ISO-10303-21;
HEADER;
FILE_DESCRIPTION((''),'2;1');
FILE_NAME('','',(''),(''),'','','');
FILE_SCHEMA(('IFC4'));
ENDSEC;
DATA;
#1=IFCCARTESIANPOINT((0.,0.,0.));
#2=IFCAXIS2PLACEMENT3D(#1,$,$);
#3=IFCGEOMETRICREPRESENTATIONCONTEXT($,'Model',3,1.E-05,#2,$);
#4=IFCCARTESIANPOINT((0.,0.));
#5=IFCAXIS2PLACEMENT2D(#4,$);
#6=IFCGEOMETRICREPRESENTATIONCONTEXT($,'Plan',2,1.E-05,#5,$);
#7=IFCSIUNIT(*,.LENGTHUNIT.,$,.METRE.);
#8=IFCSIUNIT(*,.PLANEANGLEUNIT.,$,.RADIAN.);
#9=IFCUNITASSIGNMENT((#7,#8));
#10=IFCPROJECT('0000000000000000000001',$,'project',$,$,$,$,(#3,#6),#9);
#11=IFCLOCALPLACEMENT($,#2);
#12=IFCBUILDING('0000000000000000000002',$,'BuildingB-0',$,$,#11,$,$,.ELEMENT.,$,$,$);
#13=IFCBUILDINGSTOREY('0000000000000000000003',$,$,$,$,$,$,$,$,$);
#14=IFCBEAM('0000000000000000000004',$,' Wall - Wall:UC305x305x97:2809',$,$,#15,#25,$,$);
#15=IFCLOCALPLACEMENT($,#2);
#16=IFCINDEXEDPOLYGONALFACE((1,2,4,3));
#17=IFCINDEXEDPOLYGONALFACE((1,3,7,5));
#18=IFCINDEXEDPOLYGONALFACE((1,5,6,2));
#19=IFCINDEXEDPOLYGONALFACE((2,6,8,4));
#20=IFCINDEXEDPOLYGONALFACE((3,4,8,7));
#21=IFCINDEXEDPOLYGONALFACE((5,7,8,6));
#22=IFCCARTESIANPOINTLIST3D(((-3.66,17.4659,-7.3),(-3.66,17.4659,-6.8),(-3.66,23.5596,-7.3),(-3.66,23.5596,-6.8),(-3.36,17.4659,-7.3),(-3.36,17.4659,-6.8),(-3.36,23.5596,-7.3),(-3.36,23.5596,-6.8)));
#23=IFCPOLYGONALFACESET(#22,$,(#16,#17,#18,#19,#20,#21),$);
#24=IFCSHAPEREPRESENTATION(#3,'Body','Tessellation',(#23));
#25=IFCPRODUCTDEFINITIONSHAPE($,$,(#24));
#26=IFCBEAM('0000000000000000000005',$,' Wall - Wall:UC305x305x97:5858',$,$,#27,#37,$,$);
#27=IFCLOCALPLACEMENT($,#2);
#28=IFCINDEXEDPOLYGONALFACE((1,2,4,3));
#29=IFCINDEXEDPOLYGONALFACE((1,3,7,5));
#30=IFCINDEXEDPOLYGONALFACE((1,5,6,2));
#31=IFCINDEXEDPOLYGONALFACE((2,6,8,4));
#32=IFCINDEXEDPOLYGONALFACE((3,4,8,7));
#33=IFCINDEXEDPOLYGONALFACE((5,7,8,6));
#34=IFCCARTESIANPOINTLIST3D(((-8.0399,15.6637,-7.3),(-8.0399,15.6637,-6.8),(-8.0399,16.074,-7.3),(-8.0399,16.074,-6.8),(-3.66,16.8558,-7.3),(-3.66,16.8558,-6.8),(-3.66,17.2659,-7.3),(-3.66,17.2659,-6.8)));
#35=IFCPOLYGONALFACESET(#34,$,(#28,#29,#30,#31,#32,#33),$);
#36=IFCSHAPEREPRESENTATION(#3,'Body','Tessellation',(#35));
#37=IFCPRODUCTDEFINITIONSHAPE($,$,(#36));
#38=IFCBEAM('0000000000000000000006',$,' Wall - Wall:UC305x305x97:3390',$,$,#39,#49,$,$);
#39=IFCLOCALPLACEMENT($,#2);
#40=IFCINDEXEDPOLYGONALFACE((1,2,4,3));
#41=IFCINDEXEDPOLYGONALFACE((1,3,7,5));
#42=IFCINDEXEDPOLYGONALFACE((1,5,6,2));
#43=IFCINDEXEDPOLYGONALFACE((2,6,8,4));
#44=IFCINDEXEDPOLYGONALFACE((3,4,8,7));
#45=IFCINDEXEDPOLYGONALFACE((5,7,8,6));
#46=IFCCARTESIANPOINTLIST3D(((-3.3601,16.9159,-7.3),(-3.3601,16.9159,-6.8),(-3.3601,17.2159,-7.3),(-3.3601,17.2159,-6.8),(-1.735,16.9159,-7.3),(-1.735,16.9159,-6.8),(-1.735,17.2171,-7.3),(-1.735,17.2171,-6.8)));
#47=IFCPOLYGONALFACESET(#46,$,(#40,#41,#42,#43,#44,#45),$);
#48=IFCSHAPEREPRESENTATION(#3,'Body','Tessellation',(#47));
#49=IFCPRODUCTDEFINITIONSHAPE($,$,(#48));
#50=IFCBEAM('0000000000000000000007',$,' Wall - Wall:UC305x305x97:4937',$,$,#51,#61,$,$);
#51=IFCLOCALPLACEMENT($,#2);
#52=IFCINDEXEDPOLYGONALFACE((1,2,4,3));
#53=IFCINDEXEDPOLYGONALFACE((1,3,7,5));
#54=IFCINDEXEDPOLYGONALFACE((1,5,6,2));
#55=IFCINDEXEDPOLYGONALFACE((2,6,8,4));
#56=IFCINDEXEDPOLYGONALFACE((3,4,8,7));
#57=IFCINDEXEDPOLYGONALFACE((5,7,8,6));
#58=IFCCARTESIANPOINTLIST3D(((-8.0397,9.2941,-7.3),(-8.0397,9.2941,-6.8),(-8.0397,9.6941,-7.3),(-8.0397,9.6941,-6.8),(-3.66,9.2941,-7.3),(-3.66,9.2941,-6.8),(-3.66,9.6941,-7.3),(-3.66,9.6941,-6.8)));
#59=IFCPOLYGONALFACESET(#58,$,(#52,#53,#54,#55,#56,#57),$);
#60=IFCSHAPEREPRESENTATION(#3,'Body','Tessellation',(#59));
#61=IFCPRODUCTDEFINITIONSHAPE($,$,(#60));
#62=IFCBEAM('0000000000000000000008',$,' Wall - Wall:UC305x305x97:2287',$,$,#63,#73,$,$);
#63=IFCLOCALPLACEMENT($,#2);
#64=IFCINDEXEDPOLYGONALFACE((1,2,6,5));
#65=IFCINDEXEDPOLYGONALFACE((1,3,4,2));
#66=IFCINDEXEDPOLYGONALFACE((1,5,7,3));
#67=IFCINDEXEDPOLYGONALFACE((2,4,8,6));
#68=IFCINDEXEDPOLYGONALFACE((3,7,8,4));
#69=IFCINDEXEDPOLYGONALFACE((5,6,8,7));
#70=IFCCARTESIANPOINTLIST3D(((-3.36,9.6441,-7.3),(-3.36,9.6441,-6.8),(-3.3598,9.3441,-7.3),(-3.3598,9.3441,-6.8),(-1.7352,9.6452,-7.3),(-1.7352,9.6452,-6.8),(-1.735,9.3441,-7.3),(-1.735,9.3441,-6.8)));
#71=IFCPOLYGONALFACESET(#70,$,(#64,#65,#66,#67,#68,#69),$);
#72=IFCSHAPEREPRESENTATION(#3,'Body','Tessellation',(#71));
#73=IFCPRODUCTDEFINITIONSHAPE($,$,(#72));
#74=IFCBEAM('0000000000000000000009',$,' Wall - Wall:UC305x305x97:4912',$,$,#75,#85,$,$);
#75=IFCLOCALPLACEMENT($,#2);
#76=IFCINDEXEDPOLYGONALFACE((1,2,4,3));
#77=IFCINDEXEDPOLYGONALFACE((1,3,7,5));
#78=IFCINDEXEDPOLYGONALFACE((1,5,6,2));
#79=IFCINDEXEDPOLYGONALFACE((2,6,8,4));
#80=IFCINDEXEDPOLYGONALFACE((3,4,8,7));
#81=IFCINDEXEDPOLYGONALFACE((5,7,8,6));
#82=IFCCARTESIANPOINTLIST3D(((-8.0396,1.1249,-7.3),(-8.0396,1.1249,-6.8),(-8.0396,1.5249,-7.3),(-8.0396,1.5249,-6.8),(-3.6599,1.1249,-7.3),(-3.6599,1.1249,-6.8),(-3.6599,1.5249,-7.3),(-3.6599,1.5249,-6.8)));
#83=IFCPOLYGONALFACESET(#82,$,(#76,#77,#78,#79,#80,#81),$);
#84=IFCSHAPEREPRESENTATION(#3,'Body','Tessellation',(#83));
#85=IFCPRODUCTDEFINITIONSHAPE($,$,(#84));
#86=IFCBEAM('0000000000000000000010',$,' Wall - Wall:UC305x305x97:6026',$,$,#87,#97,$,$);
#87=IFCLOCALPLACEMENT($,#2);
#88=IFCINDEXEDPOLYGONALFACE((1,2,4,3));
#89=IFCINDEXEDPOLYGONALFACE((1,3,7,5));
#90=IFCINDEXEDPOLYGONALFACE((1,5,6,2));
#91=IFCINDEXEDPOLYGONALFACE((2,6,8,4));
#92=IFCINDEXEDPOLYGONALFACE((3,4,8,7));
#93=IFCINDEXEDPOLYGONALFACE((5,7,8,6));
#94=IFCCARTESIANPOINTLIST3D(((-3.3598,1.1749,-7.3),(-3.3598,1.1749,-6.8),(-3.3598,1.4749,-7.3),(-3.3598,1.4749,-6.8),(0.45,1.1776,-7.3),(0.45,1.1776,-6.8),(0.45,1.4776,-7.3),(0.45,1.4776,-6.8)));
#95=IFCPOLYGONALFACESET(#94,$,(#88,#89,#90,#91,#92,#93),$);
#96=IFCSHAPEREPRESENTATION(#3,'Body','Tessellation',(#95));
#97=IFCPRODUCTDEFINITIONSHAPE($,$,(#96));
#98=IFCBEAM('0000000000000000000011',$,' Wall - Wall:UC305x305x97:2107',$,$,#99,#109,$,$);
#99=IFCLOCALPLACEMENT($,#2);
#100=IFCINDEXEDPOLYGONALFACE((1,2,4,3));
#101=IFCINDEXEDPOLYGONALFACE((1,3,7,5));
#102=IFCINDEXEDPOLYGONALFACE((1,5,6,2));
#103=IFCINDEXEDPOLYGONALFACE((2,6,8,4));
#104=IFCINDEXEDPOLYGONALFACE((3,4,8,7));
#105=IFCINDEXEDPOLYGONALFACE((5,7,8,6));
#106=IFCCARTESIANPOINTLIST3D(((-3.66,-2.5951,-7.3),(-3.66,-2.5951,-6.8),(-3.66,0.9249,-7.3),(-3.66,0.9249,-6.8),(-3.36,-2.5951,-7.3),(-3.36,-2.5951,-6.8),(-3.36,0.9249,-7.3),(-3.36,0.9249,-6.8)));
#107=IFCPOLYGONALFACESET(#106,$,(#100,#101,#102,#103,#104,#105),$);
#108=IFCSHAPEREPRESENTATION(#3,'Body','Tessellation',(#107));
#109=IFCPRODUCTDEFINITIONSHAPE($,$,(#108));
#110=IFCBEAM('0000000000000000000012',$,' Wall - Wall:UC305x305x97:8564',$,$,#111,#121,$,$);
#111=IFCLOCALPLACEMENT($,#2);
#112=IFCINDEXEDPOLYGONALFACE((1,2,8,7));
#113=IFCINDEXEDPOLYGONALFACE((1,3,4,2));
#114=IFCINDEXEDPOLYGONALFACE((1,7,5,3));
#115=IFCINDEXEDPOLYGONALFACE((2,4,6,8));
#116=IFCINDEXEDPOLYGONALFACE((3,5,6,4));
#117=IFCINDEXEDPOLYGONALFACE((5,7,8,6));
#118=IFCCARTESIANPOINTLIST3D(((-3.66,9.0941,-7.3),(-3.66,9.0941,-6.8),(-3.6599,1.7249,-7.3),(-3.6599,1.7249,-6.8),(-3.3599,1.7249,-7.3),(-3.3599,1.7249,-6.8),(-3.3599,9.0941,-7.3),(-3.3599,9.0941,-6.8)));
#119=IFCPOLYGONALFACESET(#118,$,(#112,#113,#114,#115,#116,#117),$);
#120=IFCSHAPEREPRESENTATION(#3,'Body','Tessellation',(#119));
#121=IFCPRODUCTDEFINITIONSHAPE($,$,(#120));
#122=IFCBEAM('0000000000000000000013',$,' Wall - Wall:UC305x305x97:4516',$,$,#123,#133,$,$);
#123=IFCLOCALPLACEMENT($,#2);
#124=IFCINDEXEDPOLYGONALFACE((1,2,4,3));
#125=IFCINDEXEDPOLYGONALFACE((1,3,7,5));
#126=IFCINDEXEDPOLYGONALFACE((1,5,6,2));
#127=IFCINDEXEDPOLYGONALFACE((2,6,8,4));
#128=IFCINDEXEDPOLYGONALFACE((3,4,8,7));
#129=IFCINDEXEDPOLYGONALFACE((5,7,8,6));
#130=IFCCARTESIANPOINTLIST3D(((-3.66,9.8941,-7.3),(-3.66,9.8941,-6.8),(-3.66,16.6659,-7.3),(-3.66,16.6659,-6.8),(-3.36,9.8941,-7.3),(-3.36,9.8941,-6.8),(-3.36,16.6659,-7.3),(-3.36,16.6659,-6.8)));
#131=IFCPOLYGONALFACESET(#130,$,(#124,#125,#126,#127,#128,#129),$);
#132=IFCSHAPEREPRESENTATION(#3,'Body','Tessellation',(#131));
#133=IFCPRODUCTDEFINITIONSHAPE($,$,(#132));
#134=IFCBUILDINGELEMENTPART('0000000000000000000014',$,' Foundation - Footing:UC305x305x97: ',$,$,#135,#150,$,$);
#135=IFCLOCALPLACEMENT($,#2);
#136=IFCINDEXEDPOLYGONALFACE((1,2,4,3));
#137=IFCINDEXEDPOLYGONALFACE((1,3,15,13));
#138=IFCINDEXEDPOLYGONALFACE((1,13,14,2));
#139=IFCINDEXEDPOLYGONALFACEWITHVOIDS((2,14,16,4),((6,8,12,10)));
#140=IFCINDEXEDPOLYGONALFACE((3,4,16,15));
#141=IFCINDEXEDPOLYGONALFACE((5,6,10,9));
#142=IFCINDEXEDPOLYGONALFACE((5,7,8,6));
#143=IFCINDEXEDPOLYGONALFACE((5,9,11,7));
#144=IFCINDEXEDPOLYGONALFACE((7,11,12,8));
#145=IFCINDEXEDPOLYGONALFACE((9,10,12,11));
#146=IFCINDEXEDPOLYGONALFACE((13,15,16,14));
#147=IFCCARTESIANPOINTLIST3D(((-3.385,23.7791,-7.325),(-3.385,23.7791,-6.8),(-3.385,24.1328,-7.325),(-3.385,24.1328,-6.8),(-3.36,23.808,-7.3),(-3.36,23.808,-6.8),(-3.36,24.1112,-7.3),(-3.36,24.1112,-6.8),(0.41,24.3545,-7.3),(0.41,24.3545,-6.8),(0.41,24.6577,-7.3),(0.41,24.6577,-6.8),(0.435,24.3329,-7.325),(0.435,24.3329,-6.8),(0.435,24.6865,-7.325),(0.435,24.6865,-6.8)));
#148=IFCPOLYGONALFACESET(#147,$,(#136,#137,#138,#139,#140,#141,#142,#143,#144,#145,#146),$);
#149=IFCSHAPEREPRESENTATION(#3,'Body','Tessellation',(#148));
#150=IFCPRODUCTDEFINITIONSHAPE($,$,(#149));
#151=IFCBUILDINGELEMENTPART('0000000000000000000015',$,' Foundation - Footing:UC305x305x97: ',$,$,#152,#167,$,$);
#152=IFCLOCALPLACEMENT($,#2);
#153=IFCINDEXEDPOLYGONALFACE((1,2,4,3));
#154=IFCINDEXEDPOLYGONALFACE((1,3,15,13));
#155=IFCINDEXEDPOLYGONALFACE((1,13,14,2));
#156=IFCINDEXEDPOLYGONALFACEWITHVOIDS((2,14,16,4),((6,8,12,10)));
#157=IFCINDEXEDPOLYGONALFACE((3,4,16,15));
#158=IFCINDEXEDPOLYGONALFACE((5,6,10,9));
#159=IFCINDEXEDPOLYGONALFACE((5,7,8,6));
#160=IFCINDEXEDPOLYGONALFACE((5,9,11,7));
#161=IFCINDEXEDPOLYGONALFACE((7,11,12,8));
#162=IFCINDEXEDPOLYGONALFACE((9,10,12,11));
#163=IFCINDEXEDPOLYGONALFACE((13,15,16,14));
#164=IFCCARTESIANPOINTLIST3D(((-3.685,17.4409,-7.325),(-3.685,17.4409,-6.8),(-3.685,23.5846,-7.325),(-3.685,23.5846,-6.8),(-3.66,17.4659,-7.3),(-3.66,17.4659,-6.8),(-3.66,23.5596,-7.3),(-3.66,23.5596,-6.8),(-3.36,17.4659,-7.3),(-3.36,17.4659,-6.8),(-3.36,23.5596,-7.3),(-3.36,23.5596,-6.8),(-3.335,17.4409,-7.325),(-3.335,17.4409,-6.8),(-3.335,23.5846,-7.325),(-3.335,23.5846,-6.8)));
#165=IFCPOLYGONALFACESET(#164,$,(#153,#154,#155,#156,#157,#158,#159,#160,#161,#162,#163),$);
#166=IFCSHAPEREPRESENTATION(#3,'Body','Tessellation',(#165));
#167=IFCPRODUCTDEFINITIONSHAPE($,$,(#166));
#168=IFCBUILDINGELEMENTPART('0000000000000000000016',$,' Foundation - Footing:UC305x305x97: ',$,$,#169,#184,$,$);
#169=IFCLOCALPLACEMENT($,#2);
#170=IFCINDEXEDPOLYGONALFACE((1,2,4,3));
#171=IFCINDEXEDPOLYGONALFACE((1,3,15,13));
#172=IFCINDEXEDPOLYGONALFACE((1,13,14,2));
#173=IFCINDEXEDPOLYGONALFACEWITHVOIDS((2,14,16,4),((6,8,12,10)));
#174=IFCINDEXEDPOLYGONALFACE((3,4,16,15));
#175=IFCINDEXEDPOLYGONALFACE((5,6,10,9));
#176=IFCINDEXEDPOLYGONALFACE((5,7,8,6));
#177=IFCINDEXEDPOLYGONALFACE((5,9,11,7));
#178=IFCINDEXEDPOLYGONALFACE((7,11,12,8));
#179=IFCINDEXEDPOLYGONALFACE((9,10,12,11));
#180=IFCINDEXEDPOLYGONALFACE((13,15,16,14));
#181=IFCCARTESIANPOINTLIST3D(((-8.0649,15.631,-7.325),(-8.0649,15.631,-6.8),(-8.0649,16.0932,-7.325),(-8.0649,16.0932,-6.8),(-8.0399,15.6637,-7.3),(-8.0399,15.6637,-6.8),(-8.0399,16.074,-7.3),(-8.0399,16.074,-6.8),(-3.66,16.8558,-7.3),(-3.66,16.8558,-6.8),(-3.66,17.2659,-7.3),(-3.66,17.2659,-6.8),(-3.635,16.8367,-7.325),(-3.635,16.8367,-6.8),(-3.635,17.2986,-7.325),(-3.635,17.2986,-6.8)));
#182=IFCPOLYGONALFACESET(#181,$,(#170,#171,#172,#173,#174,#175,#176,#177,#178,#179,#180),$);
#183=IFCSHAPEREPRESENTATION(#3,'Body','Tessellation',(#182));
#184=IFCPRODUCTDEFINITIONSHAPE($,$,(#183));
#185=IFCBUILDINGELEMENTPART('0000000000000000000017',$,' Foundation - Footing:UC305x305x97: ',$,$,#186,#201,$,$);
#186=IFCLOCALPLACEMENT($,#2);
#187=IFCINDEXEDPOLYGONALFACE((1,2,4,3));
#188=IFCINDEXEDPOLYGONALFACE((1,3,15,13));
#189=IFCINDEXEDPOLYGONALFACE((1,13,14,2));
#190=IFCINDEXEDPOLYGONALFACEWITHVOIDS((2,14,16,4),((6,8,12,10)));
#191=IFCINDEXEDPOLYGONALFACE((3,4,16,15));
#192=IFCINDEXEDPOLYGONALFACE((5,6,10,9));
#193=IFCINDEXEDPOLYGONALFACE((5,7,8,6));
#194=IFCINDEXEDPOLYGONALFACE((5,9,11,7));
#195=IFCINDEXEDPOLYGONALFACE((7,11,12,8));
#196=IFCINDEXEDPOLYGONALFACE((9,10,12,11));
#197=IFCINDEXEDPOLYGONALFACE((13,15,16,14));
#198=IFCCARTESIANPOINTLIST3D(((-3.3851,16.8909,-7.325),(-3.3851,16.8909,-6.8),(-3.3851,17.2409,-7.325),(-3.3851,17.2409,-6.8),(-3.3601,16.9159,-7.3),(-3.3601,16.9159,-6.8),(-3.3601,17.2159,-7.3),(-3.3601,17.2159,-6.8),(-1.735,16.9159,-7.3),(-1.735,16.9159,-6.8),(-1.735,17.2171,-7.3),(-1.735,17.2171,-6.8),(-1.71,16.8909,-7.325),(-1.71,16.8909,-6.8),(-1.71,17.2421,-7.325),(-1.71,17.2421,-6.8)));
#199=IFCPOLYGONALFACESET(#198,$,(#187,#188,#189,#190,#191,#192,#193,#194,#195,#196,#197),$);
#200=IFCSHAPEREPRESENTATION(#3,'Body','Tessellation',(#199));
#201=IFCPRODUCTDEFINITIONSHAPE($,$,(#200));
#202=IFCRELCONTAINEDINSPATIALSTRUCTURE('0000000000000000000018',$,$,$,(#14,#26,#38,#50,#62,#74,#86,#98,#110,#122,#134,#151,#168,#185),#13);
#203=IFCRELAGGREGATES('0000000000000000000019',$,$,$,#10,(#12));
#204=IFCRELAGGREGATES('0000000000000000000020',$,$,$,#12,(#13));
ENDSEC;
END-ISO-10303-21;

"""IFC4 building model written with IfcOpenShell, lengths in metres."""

from ifc_helpers import new_model, si_unit, origin, origin_2d, place, context, project, spatial, polyline, outline, extrude, element, save


model = new_model("IFC4")

# Units and contexts
model_context = context("Model", 3, precision=1e-05, world=origin())
plan_context = context("Plan", 2, precision=1e-05, world=origin_2d())
ifc_project = project(units=[si_unit("LENGTHUNIT", "METRE"), si_unit("PLANEANGLEUNIT", "RADIAN")], contexts=[model_context, plan_context])

# Building, storey
building_placement = place(None, origin())
building = spatial("IfcBuilding", under=ifc_project, at=building_placement, Name="BuildingB-0", CompositionType="ELEMENT")
storey = spatial("IfcBuildingStorey", under=building)

# Beams
element("IfcBeam", 1, inside=storey, Name=" Wall - Wall:UC305x305x97:2809", context=model_context, shape_type="SweptSolid", body=[
    extrude(outline(polyline([(-3.66, 23.5596, -7.3), (-3.36, 23.5596, -7.3), (-3.36, 17.4659, -7.3), (-3.66, 17.4659, -7.3), (-3.66, 23.5596, -7.3)])), None, (0.0, 0.0, 1.0), 0.5),
])
element("IfcBeam", 2, inside=storey, Name=" Wall - Wall:UC305x305x97:5858", context=model_context, shape_type="SweptSolid", body=[
    extrude(outline(polyline([(-8.0399, 15.6637, -7.3), (-8.0399, 16.074, -7.3), (-3.66, 17.2659, -7.3), (-3.66, 16.8558, -7.3), (-8.0399, 15.6637, -7.3)])), None, (0.0, 0.0, 1.0), 0.5),
])
element("IfcBeam", 3, inside=storey, Name=" Wall - Wall:UC305x305x97:3390", context=model_context, shape_type="SweptSolid", body=[
    extrude(outline(polyline([(-3.3601, 17.2159, -7.3), (-3.3601, 16.9159, -7.3), (-1.735, 16.9159, -7.3), (-1.735, 17.2171, -7.3), (-3.3601, 17.2159, -7.3)])), None, (0.0, 0.0, 1.0), 0.5),
])
element("IfcBeam", 4, inside=storey, Name=" Wall - Wall:UC305x305x97:4937", context=model_context, shape_type="SweptSolid", body=[
    extrude(outline(polyline([(-8.0397, 9.6941, -7.3), (-8.0397, 9.2941, -7.3), (-3.66, 9.2941, -7.3), (-3.66, 9.6941, -7.3), (-8.0397, 9.6941, -7.3)])), None, (0.0, 0.0, 1.0), 0.5),
])
element("IfcBeam", 5, inside=storey, Name=" Wall - Wall:UC305x305x97:2287", context=model_context, shape_type="SweptSolid", body=[
    extrude(outline(polyline([(-3.3598, 9.3441, -7.3), (-1.735, 9.3441, -7.3), (-1.7352, 9.6452, -7.3), (-3.36, 9.6441, -7.3), (-3.3598, 9.3441, -7.3)])), None, (0.0, 0.0, 1.0), 0.5),
])
element("IfcBeam", 6, inside=storey, Name=" Wall - Wall:UC305x305x97:4912", context=model_context, shape_type="SweptSolid", body=[
    extrude(outline(polyline([(-8.0396, 1.1249, -7.3), (-8.0396, 1.5249, -7.3), (-3.6599, 1.5249, -7.3), (-3.6599, 1.1249, -7.3), (-8.0396, 1.1249, -7.3)])), None, (0.0, 0.0, 1.0), 0.5),
])
element("IfcBeam", 7, inside=storey, Name=" Wall - Wall:UC305x305x97:6026", context=model_context, shape_type="SweptSolid", body=[
    extrude(outline(polyline([(-3.3598, 1.1749, -7.3), (-3.3598, 1.4749, -7.3), (0.45, 1.4776, -7.3), (0.45, 1.1776, -7.3), (-3.3598, 1.1749, -7.3)])), None, (0.0, 0.0, 1.0), 0.5),
])
element("IfcBeam", 8, inside=storey, Name=" Wall - Wall:UC305x305x97:2107", context=model_context, shape_type="SweptSolid", body=[
    extrude(outline(polyline([(-3.66, -2.5951, -7.3), (-3.36, -2.5951, -7.3), (-3.36, 0.9249, -7.3), (-3.66, 0.9249, -7.3), (-3.66, -2.5951, -7.3)])), None, (0.0, 0.0, 1.0), 0.5),
])
element("IfcBeam", 9, inside=storey, Name=" Wall - Wall:UC305x305x97:8564", context=model_context, shape_type="SweptSolid", body=[
    extrude(outline(polyline([(-3.6599, 1.7249, -7.3), (-3.3599, 1.7249, -7.3), (-3.3599, 9.0941, -7.3), (-3.66, 9.0941, -7.3), (-3.6599, 1.7249, -7.3)])), None, (0.0, 0.0, 1.0), 0.5),
])
element("IfcBeam", 10, inside=storey, Name=" Wall - Wall:UC305x305x97:4516", context=model_context, shape_type="SweptSolid", body=[
    extrude(outline(polyline([(-3.66, 9.8941, -7.3), (-3.36, 9.8941, -7.3), (-3.36, 16.6659, -7.3), (-3.66, 16.6659, -7.3), (-3.66, 9.8941, -7.3)])), None, (0.0, 0.0, 1.0), 0.5),
])

# Building element parts, openings
building_element_part_1 = element("IfcBuildingElementPart", 11, inside=storey, Name=" Foundation - Footing:UC305x305x97: ", context=model_context, shape_type="SweptSolid", body=[
    extrude(outline(polyline([(-3.385, 23.7791, -7.325), (0.435, 24.3329, -7.325), (0.435, 24.6865, -7.325), (-3.385, 24.1328, -7.325), (-3.385, 23.7791, -7.325)])), None, (0.0, 0.0, 1.0), 0.525),
])
element("IfcOpeningElement", 12, inside=storey, cuts=building_element_part_1, context=model_context, shape_type="SweptSolid", body=[
    extrude(outline(polyline([(-3.36, 23.808, -7.3), (0.41, 24.3545, -7.3), (0.41, 24.6577, -7.3), (-3.36, 24.1112, -7.3), (-3.36, 23.808, -7.3)])), None, (0.0, 0.0, 1.0), 0.5),
])
building_element_part_2 = element("IfcBuildingElementPart", 13, inside=storey, Name=" Foundation - Footing:UC305x305x97: ", context=model_context, shape_type="SweptSolid", body=[
    extrude(outline(polyline([(-3.685, 23.5846, -7.325), (-3.335, 23.5846, -7.325), (-3.335, 17.4409, -7.325), (-3.685, 17.4409, -7.325), (-3.685, 23.5846, -7.325)])), None, (0.0, 0.0, 1.0), 0.525),
])
element("IfcOpeningElement", 14, inside=storey, cuts=building_element_part_2, context=model_context, shape_type="SweptSolid", body=[
    extrude(outline(polyline([(-3.66, 23.5596, -7.3), (-3.36, 23.5596, -7.3), (-3.36, 17.4659, -7.3), (-3.66, 17.4659, -7.3), (-3.66, 23.5596, -7.3)])), None, (0.0, 0.0, 1.0), 0.5),
])
building_element_part_3 = element("IfcBuildingElementPart", 15, inside=storey, Name=" Foundation - Footing:UC305x305x97: ", context=model_context, shape_type="SweptSolid", body=[
    extrude(outline(polyline([(-8.0649, 15.631, -7.325), (-8.0649, 16.0932, -7.325), (-3.635, 17.2986, -7.325), (-3.635, 16.8367, -7.325), (-8.0649, 15.631, -7.325)])), None, (0.0, 0.0, 1.0), 0.525),
])
element("IfcOpeningElement", 16, inside=storey, cuts=building_element_part_3, context=model_context, shape_type="SweptSolid", body=[
    extrude(outline(polyline([(-8.0399, 15.6637, -7.3), (-8.0399, 16.074, -7.3), (-3.66, 17.2659, -7.3), (-3.66, 16.8558, -7.3), (-8.0399, 15.6637, -7.3)])), None, (0.0, 0.0, 1.0), 0.5),
])
building_element_part_4 = element("IfcBuildingElementPart", 17, inside=storey, Name=" Foundation - Footing:UC305x305x97: ", context=model_context, shape_type="SweptSolid", body=[
    extrude(outline(polyline([(-3.3851, 17.2409, -7.325), (-3.3851, 16.8909, -7.325), (-1.71, 16.8909, -7.325), (-1.71, 17.2421, -7.325), (-3.3851, 17.2409, -7.325)])), None, (0.0, 0.0, 1.0), 0.525),
])
element("IfcOpeningElement", 18, inside=storey, cuts=building_element_part_4, context=model_context, shape_type="SweptSolid", body=[
    extrude(outline(polyline([(-3.3601, 17.2159, -7.3), (-3.3601, 16.9159, -7.3), (-1.735, 16.9159, -7.3), (-1.735, 17.2171, -7.3), (-3.3601, 17.2159, -7.3)])), None, (0.0, 0.0, 1.0), 0.5),
])

save(model, "model.ifc")
